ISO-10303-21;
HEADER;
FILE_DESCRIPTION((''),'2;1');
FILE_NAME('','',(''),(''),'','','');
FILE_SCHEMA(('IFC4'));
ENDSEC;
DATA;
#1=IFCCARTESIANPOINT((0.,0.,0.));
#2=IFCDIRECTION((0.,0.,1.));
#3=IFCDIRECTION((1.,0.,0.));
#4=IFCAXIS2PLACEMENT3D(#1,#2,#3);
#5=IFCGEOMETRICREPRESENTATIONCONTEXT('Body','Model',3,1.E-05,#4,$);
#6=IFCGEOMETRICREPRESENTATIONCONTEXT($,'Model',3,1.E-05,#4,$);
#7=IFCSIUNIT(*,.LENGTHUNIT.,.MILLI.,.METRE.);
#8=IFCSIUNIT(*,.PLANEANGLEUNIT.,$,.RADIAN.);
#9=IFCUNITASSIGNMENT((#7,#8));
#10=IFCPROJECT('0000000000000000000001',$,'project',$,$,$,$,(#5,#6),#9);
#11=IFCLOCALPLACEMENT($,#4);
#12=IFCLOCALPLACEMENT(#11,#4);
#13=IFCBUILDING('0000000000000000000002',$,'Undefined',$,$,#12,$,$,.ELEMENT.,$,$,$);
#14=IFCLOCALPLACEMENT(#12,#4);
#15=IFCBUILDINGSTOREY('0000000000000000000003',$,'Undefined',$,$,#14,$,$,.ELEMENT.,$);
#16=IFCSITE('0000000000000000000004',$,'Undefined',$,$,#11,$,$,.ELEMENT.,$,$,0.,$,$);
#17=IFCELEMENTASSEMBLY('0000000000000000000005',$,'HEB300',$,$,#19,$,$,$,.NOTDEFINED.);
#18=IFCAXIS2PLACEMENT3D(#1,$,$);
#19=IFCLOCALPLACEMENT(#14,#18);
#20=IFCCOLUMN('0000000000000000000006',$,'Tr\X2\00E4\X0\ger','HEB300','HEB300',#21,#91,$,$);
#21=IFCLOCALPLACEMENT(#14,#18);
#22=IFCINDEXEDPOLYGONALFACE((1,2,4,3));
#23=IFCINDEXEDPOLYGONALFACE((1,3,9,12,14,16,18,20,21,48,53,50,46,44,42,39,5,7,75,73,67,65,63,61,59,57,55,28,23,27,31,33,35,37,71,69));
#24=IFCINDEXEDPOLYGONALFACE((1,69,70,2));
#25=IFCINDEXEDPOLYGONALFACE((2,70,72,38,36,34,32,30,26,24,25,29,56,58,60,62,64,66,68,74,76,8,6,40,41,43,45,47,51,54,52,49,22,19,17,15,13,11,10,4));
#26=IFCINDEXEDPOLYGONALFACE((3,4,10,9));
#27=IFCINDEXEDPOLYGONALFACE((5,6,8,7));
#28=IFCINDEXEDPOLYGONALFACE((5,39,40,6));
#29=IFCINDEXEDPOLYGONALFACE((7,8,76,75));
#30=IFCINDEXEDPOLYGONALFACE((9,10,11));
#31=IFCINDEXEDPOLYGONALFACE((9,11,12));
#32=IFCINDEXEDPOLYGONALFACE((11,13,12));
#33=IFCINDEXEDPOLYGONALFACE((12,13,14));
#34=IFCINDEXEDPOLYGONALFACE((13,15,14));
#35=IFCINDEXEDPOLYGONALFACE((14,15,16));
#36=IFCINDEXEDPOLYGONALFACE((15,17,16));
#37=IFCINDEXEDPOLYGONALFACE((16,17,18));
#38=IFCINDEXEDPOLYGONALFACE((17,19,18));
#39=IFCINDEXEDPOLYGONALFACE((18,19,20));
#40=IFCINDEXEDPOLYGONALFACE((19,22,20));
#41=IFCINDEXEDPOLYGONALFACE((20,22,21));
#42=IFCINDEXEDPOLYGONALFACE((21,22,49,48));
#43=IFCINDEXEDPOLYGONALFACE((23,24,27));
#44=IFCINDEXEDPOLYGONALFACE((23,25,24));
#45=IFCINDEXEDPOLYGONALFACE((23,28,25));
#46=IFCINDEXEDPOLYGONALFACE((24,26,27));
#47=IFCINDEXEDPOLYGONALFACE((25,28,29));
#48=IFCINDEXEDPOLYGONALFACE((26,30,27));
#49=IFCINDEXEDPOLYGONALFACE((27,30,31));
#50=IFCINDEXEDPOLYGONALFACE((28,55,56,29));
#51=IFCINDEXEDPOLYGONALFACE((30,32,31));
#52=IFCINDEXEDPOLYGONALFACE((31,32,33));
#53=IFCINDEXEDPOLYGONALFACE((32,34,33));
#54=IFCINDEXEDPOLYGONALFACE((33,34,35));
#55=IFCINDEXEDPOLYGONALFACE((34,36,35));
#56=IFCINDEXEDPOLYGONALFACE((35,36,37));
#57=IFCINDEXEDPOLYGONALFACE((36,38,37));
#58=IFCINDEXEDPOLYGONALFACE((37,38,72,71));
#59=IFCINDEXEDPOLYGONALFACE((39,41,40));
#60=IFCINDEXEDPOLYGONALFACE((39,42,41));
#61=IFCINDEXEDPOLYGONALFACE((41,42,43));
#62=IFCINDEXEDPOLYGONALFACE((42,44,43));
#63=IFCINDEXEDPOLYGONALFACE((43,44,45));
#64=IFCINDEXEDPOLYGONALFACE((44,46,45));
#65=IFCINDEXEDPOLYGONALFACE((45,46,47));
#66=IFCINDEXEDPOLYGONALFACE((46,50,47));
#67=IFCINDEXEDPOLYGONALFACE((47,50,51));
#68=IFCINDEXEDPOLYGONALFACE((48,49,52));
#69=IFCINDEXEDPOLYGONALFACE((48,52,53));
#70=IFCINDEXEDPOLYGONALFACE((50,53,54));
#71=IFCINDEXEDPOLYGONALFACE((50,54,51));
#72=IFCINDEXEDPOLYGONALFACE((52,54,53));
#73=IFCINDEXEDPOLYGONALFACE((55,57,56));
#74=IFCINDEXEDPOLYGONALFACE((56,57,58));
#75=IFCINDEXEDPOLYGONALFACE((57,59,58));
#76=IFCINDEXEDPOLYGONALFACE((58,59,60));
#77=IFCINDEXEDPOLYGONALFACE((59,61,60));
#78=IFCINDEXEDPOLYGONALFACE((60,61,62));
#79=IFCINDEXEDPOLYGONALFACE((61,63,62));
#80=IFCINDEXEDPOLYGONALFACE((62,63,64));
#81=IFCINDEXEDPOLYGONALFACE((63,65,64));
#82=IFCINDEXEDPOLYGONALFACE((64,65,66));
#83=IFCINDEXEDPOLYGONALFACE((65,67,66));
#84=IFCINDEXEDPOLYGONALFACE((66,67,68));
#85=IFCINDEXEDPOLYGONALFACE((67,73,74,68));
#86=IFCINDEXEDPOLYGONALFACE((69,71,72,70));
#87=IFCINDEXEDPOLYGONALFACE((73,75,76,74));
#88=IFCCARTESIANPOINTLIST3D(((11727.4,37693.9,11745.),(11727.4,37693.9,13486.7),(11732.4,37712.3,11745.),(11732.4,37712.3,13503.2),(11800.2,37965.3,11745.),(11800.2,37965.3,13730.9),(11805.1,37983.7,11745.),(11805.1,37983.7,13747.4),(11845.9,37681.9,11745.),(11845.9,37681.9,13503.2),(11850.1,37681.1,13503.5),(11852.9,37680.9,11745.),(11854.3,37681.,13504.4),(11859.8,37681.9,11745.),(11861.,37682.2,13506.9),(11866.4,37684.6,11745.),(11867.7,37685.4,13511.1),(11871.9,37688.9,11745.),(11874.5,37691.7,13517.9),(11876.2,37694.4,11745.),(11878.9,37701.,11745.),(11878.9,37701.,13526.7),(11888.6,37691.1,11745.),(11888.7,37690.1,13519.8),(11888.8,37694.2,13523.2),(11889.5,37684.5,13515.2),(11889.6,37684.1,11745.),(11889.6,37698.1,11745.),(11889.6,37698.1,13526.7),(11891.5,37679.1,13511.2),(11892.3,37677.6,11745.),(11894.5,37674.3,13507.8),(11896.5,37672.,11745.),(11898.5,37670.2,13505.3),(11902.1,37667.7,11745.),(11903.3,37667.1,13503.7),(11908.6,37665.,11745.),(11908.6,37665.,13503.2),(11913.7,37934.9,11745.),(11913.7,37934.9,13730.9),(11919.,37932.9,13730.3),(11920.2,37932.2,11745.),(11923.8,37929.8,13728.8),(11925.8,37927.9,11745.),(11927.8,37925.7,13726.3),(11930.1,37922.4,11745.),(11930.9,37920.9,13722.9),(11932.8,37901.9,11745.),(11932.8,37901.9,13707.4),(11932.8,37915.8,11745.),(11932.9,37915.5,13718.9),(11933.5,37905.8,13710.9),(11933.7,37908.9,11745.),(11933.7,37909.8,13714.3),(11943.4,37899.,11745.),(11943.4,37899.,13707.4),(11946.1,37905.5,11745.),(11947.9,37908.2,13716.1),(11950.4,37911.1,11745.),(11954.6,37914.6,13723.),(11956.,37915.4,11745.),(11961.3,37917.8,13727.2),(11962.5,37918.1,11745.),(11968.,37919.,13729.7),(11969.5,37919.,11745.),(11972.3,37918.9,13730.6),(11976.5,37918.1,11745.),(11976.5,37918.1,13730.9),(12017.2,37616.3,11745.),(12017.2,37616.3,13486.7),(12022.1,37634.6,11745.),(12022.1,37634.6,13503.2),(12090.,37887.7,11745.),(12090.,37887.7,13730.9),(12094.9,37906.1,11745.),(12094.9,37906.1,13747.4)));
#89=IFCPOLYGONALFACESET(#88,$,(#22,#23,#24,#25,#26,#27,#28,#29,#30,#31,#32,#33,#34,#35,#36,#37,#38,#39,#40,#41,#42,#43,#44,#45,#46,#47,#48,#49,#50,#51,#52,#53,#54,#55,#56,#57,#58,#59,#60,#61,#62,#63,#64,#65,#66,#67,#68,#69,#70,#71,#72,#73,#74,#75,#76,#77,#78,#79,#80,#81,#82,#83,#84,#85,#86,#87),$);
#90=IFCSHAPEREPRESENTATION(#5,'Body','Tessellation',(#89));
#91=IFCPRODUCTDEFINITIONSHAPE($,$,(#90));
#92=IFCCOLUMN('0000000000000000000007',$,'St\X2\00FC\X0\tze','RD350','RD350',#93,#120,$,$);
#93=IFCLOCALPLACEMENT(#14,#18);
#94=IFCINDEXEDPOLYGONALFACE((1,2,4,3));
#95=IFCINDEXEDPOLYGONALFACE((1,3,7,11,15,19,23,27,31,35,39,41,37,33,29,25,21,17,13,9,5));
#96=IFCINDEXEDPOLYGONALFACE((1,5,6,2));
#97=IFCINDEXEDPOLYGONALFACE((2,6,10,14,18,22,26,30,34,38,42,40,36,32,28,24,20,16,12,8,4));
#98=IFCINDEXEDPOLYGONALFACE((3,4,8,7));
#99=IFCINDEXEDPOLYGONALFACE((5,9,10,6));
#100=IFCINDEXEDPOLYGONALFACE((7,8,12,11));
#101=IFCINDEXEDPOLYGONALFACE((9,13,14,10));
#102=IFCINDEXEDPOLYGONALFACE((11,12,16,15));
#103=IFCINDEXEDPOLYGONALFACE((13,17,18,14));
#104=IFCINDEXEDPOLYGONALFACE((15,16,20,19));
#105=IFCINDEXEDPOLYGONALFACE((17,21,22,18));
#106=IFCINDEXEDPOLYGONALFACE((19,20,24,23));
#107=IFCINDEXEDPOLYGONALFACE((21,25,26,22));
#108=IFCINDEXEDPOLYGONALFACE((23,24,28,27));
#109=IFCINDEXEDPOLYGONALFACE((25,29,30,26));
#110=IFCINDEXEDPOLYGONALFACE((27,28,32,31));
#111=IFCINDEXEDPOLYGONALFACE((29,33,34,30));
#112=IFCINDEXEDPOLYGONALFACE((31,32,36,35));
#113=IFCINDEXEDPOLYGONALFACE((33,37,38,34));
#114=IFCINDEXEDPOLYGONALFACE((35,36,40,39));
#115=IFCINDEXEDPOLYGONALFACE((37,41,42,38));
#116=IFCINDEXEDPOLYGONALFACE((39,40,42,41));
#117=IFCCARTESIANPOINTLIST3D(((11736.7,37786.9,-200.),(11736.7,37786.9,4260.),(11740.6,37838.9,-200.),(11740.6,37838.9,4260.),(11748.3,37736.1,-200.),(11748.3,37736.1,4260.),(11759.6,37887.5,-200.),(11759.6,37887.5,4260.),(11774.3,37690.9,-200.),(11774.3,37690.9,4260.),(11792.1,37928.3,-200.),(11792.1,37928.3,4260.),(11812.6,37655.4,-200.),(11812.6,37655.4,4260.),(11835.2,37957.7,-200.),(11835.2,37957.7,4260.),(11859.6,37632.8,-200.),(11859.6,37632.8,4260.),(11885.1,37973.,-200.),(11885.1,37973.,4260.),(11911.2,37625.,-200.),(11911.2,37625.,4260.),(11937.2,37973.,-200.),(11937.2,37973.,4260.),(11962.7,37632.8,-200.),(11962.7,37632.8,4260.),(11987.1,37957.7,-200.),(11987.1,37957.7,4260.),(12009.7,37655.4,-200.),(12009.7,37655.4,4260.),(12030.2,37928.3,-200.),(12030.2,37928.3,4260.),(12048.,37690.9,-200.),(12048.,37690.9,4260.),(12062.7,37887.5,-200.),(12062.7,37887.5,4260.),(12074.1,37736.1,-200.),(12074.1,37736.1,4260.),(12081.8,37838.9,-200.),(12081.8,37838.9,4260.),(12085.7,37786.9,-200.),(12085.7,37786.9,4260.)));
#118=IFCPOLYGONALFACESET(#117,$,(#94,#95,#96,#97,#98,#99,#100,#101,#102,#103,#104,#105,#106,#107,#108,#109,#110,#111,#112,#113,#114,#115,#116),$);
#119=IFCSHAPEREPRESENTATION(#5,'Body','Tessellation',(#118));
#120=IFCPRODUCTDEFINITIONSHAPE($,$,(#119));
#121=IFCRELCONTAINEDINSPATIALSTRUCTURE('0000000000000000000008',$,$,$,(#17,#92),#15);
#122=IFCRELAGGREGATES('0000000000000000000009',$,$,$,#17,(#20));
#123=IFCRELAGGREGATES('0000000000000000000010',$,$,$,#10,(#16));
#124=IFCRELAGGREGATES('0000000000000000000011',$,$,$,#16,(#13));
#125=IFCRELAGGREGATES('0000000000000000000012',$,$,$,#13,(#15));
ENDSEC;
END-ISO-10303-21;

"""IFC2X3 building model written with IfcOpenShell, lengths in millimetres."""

from ifc_helpers import new_model, si_unit, frame, origin_with_axes, origin_2d_with_axis, place, context, project, spatial, circle, i_section, extrude, clip, halfspace, element, aggregate, save


model = new_model("IFC2X3")

# Units and contexts
model_context_1 = context("Model", 3, precision=1e-05, world=origin_with_axes(), identifier="Body")
model_context_2 = context("Model", 3, precision=1e-05, world=origin_with_axes())
ifc_project = project(units=[si_unit("LENGTHUNIT", "METRE", prefix="MILLI"), si_unit("PLANEANGLEUNIT", "RADIAN")], contexts=[model_context_1, model_context_2])

# Site, building, storey
site_placement = place(None, origin_with_axes())
site = spatial("IfcSite", under=ifc_project, at=site_placement, Name="Undefined", CompositionType="ELEMENT", RefElevation=0.0)
building_placement = place(site_placement, origin_with_axes())
building = spatial("IfcBuilding", under=site, at=building_placement, Name="Undefined", CompositionType="ELEMENT")
storey_placement = place(building_placement, origin_with_axes())
storey = spatial("IfcBuildingStorey", under=building, at=storey_placement, Name="Undefined", CompositionType="ELEMENT")

# Element assembly, column
assembly_1 = element("IfcElementAssembly", 1, inside=storey, Name="HEB300", PredefinedType="NOTDEFINED")
column_1_placement = place(storey_placement, frame((11911.2, 37800.0, 11901.5), z_axis=(0.0, 0.0, 1.0), x_axis=(1.0, 0.0, 0.0)))
column_1 = element("IfcColumn", 2, at=column_1_placement, Name="Träger", Description="HEB300", ObjectType="HEB300", context=model_context_1, shape_type="Clipping", body=[
    clip(clip(extrude(i_section(OverallWidth=300.0, OverallDepth=300.0, WebThickness=11.0, FlangeThickness=19.0, FilletRadius=27.0, at=origin_2d_with_axis()), frame((0.0, 0.0, 1847.1), z_axis=(0.0, 0.0, -1.0), x_axis=(0.965926, -0.258819, 0.0)), (0.0, 0.0, 1.0), 2003.7), halfspace(frame((125.4, -111.5, -156.5), z_axis=(0.0, 0.0, -1.0), x_axis=(0.965926, -0.258819, 0.0)), False)), halfspace(frame((9.5, -157.8, 1585.2), z_axis=(0.169762, 0.633562, -0.754838), x_axis=(0.965926, -0.258819, 0.0)), True)),
])
aggregate(assembly_1, [column_1])

# Column
column_2_placement = place(storey_placement, frame((11911.2, 37800.0, -200.0), z_axis=(0.0, 0.0, 1.0), x_axis=(1.0, 0.0, 0.0)))
element("IfcColumn", 3, at=column_2_placement, inside=storey, Name="Stütze", Description="RD350", ObjectType="RD350", context=model_context_1, shape_type="SweptSolid", body=[
    extrude(circle(Radius=175.0, at=origin_2d_with_axis()), frame((0.0, 0.0, 4460.0), z_axis=(0.0, 0.0, -1.0), x_axis=(-0.866025, 0.500001, 0.0)), (0.0, 0.0, 1.0), 4460.0),
])

save(model, "model.ifc")
